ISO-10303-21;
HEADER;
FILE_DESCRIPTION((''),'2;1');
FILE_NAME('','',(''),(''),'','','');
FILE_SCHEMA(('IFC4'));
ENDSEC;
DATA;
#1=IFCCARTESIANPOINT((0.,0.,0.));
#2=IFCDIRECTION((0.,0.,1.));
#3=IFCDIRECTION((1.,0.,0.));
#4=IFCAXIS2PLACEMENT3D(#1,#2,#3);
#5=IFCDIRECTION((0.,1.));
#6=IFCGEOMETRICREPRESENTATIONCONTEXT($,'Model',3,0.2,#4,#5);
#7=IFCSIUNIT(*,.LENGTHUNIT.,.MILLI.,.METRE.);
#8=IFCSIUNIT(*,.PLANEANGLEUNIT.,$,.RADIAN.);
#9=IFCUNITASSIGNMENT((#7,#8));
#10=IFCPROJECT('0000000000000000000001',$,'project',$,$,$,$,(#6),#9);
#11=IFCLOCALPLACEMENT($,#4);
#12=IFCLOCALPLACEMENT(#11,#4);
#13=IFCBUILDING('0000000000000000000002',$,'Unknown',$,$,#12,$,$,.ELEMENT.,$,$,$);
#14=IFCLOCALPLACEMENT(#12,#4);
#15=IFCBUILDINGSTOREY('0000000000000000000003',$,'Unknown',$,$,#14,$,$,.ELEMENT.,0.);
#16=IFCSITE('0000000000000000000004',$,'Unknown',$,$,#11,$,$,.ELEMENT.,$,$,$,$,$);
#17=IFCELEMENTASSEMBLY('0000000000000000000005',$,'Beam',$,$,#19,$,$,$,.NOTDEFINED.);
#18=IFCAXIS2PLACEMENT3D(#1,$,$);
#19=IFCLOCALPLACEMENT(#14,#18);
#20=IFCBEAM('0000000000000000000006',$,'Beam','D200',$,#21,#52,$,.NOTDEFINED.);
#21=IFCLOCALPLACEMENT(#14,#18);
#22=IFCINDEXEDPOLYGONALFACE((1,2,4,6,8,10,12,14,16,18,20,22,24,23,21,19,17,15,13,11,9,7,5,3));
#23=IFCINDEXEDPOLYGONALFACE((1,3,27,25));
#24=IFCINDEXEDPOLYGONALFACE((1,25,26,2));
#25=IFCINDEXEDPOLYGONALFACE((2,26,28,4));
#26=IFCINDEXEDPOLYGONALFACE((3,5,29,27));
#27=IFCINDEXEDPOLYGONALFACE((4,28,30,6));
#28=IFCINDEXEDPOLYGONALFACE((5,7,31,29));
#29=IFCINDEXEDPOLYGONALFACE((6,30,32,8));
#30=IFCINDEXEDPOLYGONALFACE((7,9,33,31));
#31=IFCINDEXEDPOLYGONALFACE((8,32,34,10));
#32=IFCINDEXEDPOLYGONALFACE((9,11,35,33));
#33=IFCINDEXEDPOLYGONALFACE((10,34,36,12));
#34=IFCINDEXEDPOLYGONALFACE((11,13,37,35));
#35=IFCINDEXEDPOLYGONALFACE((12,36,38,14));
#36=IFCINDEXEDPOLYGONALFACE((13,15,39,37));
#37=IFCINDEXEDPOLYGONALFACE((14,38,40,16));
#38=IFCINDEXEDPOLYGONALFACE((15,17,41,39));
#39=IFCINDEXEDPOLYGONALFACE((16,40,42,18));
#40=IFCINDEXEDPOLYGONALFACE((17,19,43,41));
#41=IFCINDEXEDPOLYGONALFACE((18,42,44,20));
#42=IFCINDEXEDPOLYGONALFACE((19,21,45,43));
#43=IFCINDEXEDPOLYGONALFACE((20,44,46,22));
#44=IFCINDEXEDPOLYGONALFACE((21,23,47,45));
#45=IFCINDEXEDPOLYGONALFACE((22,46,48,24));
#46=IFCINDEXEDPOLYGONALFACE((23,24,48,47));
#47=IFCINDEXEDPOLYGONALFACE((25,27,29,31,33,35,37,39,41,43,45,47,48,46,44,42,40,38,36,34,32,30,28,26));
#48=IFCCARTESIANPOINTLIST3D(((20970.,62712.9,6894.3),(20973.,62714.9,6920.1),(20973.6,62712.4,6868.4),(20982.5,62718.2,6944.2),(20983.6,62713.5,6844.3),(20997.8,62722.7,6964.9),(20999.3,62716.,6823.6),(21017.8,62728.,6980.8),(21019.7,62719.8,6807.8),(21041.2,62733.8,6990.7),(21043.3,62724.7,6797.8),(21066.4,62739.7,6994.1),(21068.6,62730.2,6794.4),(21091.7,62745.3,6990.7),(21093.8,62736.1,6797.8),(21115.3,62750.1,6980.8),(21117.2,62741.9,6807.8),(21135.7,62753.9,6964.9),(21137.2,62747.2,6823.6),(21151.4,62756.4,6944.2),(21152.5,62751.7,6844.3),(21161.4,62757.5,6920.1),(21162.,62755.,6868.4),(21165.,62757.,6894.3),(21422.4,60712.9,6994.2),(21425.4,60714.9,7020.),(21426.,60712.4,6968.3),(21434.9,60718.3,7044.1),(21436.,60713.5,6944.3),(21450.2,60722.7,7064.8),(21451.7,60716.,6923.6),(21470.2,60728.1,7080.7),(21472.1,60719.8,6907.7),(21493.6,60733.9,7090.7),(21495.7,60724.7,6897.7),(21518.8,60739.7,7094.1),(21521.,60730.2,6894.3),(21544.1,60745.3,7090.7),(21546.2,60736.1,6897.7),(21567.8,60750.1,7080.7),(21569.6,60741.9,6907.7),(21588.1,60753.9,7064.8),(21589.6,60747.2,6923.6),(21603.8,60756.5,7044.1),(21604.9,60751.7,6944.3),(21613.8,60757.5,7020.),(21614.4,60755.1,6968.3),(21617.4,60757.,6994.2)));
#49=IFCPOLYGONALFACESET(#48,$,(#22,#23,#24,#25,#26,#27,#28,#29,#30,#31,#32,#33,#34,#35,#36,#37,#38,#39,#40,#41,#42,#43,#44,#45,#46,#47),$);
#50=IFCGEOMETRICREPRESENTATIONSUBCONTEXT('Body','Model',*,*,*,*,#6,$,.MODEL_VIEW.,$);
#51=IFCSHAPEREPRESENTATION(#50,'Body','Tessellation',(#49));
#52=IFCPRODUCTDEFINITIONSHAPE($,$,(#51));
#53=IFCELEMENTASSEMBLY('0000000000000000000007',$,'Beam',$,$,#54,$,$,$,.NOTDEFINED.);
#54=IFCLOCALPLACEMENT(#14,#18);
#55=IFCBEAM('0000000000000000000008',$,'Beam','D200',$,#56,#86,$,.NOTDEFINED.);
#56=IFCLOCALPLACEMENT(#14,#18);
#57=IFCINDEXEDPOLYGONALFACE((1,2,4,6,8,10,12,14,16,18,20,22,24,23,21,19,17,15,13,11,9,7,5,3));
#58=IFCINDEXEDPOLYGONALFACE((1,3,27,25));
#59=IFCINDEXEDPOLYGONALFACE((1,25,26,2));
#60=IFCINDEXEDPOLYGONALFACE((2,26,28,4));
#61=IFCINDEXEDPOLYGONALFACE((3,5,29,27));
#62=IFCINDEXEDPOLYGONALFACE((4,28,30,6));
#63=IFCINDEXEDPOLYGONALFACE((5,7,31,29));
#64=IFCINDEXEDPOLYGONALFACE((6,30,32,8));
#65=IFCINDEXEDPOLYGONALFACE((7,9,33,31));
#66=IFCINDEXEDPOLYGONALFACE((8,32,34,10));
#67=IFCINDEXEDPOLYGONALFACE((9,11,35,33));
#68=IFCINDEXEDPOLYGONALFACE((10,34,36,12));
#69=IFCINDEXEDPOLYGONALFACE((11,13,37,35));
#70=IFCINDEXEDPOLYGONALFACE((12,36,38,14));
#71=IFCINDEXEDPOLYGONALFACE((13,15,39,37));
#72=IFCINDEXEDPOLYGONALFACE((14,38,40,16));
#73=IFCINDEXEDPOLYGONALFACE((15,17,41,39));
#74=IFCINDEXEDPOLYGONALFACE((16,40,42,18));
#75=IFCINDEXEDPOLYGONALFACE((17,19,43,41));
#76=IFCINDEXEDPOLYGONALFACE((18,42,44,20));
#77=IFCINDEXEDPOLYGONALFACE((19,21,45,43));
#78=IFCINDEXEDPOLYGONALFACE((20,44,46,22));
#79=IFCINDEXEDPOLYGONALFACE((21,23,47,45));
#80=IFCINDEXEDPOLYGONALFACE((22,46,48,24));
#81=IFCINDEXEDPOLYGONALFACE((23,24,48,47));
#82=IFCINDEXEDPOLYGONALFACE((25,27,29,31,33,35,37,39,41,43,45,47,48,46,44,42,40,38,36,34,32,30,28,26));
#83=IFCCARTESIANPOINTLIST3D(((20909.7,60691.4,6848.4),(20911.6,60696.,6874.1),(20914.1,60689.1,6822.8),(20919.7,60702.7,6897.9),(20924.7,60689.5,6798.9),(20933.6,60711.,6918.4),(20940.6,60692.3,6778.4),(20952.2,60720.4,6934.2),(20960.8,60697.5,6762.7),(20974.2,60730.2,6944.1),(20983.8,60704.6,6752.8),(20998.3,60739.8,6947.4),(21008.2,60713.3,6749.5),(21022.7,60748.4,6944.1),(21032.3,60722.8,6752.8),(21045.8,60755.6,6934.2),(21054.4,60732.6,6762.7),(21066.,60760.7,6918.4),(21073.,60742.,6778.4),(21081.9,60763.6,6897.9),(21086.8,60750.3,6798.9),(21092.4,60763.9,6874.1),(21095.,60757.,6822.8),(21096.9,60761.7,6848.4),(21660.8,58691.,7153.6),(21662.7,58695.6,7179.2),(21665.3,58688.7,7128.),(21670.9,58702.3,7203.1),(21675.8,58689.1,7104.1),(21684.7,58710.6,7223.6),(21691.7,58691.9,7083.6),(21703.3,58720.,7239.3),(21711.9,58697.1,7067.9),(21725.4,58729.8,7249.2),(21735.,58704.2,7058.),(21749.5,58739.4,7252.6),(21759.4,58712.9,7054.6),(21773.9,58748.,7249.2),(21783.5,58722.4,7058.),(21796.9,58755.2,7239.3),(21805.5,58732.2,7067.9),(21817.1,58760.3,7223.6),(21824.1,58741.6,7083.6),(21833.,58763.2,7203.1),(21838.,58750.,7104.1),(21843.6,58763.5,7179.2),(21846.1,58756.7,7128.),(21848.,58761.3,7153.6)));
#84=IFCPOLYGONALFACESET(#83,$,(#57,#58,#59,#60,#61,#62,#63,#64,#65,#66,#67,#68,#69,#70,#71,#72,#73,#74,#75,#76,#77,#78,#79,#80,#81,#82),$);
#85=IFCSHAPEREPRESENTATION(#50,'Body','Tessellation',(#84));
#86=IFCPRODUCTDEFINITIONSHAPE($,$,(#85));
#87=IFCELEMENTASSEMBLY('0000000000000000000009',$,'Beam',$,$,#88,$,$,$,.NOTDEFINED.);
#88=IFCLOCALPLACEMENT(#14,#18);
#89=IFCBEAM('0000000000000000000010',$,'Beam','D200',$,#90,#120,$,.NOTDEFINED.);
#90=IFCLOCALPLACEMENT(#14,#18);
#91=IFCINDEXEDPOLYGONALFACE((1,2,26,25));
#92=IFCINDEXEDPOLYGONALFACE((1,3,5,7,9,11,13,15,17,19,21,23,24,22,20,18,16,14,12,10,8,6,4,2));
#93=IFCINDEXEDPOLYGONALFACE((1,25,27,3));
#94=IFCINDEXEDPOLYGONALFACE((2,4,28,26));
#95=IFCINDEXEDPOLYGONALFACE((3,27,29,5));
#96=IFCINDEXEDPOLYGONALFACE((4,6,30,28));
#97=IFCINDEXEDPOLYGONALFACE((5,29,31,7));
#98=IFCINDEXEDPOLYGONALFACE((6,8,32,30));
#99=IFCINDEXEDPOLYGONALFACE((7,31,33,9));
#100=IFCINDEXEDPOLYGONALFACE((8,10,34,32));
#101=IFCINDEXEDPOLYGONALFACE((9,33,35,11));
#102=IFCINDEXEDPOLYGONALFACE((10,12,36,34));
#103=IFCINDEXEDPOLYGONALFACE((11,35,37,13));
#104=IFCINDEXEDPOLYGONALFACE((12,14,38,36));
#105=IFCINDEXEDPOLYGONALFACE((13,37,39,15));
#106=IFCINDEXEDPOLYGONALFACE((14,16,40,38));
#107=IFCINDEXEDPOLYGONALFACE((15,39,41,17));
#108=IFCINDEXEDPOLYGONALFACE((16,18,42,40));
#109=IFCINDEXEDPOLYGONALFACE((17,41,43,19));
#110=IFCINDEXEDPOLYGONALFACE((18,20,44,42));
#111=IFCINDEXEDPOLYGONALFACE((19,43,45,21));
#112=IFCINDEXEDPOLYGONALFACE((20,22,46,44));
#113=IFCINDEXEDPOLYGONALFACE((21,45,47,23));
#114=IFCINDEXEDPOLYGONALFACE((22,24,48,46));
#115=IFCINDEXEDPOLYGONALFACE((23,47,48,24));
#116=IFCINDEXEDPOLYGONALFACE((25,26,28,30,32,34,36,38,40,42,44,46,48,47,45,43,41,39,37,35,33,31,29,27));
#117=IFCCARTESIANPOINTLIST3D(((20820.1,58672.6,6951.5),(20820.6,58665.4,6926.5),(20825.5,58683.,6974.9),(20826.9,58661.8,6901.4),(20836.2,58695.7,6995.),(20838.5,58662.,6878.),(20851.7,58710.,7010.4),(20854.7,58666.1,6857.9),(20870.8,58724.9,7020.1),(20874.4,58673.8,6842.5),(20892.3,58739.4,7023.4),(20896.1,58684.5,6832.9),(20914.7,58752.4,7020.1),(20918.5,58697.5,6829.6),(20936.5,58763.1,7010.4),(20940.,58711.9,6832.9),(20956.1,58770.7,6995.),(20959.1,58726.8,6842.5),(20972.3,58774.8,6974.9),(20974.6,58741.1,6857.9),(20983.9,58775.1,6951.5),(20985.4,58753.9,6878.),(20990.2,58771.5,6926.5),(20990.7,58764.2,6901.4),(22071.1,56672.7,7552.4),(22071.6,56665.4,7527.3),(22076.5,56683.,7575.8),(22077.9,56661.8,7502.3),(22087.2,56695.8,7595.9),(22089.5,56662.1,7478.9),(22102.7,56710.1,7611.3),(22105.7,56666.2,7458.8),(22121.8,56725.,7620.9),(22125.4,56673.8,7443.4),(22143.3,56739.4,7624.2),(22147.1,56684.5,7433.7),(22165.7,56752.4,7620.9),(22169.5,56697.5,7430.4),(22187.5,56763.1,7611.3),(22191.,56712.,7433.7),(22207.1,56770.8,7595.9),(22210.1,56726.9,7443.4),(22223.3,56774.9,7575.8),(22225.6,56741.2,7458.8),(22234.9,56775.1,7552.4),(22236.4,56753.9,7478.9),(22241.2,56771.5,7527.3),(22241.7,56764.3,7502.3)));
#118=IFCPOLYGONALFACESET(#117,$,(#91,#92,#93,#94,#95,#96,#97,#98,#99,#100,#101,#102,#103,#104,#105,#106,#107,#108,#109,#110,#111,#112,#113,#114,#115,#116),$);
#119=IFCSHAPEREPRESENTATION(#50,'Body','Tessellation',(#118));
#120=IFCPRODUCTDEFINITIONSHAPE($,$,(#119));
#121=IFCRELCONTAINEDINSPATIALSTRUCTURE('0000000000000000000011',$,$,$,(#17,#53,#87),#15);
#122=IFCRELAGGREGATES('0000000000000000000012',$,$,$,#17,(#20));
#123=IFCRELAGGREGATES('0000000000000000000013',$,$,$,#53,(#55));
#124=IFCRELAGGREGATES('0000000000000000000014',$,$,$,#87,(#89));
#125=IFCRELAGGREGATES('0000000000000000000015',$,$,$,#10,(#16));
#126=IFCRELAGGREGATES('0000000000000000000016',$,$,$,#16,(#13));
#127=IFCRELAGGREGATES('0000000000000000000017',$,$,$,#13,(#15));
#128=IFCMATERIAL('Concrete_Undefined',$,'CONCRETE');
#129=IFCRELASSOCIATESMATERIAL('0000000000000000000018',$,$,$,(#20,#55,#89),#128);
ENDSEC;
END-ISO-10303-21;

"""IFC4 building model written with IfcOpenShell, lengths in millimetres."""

from ifc_helpers import new_model, si_unit, direction, frame, origin_with_axes, place, context, subcontext, project, spatial, line, indexed_curve, outline, extrude, material, element, aggregate, save


model = new_model("IFC4")

# Units and contexts
model_context = context("Model", 3, precision=0.2, world=origin_with_axes(), true_north=direction((0.0, 1.0)))
body_context = subcontext(model_context, "Body", "Model", "MODEL_VIEW")
ifc_project = project(units=[si_unit("LENGTHUNIT", "METRE", prefix="MILLI"), si_unit("PLANEANGLEUNIT", "RADIAN")], contexts=[model_context])

# Site, building, storey
site_placement = place(None, origin_with_axes())
site = spatial("IfcSite", under=ifc_project, at=site_placement, Name="Unknown", CompositionType="ELEMENT")
building_placement = place(site_placement, origin_with_axes())
building = spatial("IfcBuilding", under=site, at=building_placement, Name="Unknown", CompositionType="ELEMENT")
storey_placement = place(building_placement, origin_with_axes())
storey = spatial("IfcBuildingStorey", under=building, at=storey_placement, Name="Unknown", CompositionType="ELEMENT", Elevation=0.0)

# Element assemblies, beams
ifc_material = material(Name="Concrete_Undefined", Category="CONCRETE")
assembly_1_placement = place(storey_placement, frame((21067.5, 62735.0, 6894.3), z_axis=(-0.975357, -0.220631, 0.0), x_axis=(0.220369, -0.974201, 0.048676)))
assembly_1 = element("IfcElementAssembly", 1, at=assembly_1_placement, inside=storey, Name="Beam", PredefinedType="NOTDEFINED")
beam_1_placement = place(assembly_1_placement, origin_with_axes())
beam_1 = element("IfcBeam", 2, at=beam_1_placement, material=ifc_material, Name="Beam", Description="D200", PredefinedType="NOTDEFINED", context=body_context, shape_type="SolidModel", body=[
    extrude(outline(indexed_curve([(100.0, 0.0), (96.6, 25.9), (86.6, 50.0), (70.7, 70.7), (50.0, 86.6), (25.9, 96.6), (0.0, 100.0), (-25.9, 96.6), (-50.0, 86.6), (-70.7, 70.7), (-86.6, 50.0), (-96.6, 25.9), (-100.0, 0.0), (-96.6, -25.9), (-86.6, -50.0), (-70.7, -70.7), (-50.0, -86.6), (-25.9, -96.6), (0.0, -100.0), (25.9, -96.6), (50.0, -86.6), (70.7, -70.7), (86.6, -50.0), (96.6, -25.9)], segments=[line(1, 2, 3, 4, 5, 6, 7, 8, 9, 10, 11, 12, 13, 14, 15, 16, 17, 18, 19, 20, 21, 22, 23, 24, 1)])), frame((0.0, 0.0, 0.0), z_axis=(-1.0, 0.0, 0.0), x_axis=(0.0, 0.0, 1.0)), (0.0, 0.0, -1.0), 2052.9),
])
aggregate(assembly_1, [beam_1])
assembly_2_placement = place(storey_placement, frame((21003.3, 60726.5, 6848.4), z_axis=(-0.936174, -0.351537, 0.0), x_axis=(0.348006, -0.926772, 0.141371)))
assembly_2 = element("IfcElementAssembly", 3, at=assembly_2_placement, inside=storey, Name="Beam", PredefinedType="NOTDEFINED")
beam_2_placement = place(assembly_2_placement, origin_with_axes())
beam_2 = element("IfcBeam", 4, at=beam_2_placement, material=ifc_material, Name="Beam", Description="D200", PredefinedType="NOTDEFINED", context=body_context, shape_type="SolidModel", body=[
    extrude(outline(indexed_curve([(100.0, 0.0), (96.6, 25.9), (86.6, 50.0), (70.7, 70.7), (50.0, 86.6), (25.9, 96.6), (0.0, 100.0), (-25.9, 96.6), (-50.0, 86.6), (-70.7, 70.7), (-86.6, 50.0), (-96.6, 25.9), (-100.0, 0.0), (-96.6, -25.9), (-86.6, -50.0), (-70.7, -70.7), (-50.0, -86.6), (-25.9, -96.6), (0.0, -100.0), (25.9, -96.6), (50.0, -86.6), (70.7, -70.7), (86.6, -50.0), (96.6, -25.9)], segments=[line(1, 2, 3, 4, 5, 6, 7, 8, 9, 10, 11, 12, 13, 14, 15, 16, 17, 18, 19, 20, 21, 22, 23, 24, 1)])), frame((0.0, 0.0, 0.0), z_axis=(-1.0, 0.0, 0.0), x_axis=(0.0, 0.0, 1.0)), (0.0, 0.0, -1.0), 2158.4),
])
aggregate(assembly_2, [beam_2])
assembly_3_placement = place(storey_placement, frame((20905.4, 58718.4, 6926.5), z_axis=(-0.847802, -0.530313, 0.0), x_axis=(0.513904, -0.821568, 0.246838)))
assembly_3 = element("IfcElementAssembly", 5, at=assembly_3_placement, inside=storey, Name="Beam", PredefinedType="NOTDEFINED")
beam_3_placement = place(assembly_3_placement, origin_with_axes())
beam_3 = element("IfcBeam", 6, at=beam_3_placement, material=ifc_material, Name="Beam", Description="D200", PredefinedType="NOTDEFINED", context=body_context, shape_type="SolidModel", body=[
    extrude(outline(indexed_curve([(100.0, 0.0), (96.6, 25.9), (86.6, 50.0), (70.7, 70.7), (50.0, 86.6), (25.9, 96.6), (0.0, 100.0), (-25.9, 96.6), (-50.0, 86.6), (-70.7, 70.7), (-86.6, 50.0), (-96.6, 25.9), (-100.0, 0.0), (-96.6, -25.9), (-86.6, -50.0), (-70.7, -70.7), (-50.0, -86.6), (-25.9, -96.6), (0.0, -100.0), (25.9, -96.6), (50.0, -86.6), (70.7, -70.7), (86.6, -50.0), (96.6, -25.9)], segments=[line(1, 2, 3, 4, 5, 6, 7, 8, 9, 10, 11, 12, 13, 14, 15, 16, 17, 18, 19, 20, 21, 22, 23, 24, 1)])), frame((0.0, 0.0, 0.0), z_axis=(-1.0, 0.0, 0.0), x_axis=(0.0, 0.0, 1.0)), (0.0, 0.0, -1.0), 2434.3),
])
aggregate(assembly_3, [beam_3])

save(model, "model.ifc")
